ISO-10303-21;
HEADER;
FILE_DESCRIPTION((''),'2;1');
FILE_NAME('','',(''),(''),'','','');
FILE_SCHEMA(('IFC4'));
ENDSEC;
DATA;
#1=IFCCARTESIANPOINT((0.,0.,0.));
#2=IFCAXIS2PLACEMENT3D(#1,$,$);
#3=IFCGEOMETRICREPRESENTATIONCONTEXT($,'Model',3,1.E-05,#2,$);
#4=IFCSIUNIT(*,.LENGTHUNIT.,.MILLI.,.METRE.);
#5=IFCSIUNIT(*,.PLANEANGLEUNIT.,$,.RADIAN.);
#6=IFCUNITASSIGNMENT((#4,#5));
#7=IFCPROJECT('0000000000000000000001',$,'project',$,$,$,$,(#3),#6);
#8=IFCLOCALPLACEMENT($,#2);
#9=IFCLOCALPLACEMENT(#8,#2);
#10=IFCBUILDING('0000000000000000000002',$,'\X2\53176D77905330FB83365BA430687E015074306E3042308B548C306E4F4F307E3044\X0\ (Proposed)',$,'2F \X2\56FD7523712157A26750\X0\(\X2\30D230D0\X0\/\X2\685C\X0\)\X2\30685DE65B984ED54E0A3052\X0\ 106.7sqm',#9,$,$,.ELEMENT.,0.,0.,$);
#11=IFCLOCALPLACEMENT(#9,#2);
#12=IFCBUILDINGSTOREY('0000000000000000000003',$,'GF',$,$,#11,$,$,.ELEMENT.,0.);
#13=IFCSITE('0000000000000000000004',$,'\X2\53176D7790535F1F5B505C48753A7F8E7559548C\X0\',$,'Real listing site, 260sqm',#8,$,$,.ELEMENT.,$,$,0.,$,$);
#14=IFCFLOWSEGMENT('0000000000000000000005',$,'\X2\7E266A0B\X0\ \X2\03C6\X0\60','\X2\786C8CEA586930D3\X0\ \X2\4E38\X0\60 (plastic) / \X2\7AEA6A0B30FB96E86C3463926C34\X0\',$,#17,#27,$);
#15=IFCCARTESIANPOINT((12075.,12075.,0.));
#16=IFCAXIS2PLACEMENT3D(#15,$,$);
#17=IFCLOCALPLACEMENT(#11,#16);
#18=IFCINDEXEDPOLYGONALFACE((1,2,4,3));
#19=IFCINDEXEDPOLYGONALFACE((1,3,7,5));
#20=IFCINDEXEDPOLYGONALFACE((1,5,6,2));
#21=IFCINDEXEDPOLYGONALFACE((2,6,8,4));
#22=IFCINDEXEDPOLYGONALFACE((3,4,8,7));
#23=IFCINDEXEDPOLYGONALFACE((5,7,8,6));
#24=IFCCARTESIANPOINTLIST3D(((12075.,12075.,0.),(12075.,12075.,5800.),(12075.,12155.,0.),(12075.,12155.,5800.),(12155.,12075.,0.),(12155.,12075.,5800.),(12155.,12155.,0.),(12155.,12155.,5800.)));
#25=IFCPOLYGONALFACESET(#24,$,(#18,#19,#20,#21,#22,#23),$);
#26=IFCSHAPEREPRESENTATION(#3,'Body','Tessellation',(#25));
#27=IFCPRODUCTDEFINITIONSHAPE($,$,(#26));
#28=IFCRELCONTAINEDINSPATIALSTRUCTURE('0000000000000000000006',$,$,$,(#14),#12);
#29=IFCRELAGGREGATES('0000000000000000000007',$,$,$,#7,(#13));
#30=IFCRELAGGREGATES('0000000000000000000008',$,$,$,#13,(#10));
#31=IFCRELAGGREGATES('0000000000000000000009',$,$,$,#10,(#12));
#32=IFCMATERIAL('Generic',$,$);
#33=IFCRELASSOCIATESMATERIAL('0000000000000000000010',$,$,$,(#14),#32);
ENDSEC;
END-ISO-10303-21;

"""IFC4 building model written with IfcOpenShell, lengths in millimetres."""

from ifc_helpers import new_model, si_unit, frame, frame_2d, origin, place, context, project, spatial, rectangle, extrude, material, element, save


model = new_model("IFC4")

# Units and contexts
model_context = context("Model", 3, precision=1e-05, world=origin())
ifc_project = project(units=[si_unit("LENGTHUNIT", "METRE", prefix="MILLI"), si_unit("PLANEANGLEUNIT", "RADIAN")], contexts=[model_context])

# Site, building, storey
site_placement = place(None, origin())
site = spatial("IfcSite", under=ifc_project, at=site_placement, Name="北海道弟子屈町美留和", ObjectType="Real listing site, 260sqm", CompositionType="ELEMENT", RefElevation=0.0)
building_placement = place(site_placement, origin())
building = spatial("IfcBuilding", under=site, at=building_placement, Name="北海道・茶室と縁側のある和の住まい (Proposed)", ObjectType="2F 国産無垢材(ヒバ/桜)と左官仕上げ 106.7sqm", CompositionType="ELEMENT", ElevationOfRefHeight=0.0, ElevationOfTerrain=0.0)
storey_placement = place(building_placement, origin())
storey = spatial("IfcBuildingStorey", under=building, at=storey_placement, Name="GF", CompositionType="ELEMENT", Elevation=0.0)

# Flow segment
ifc_material_1 = material(Name="Generic")
flow_segment_placement = place(storey_placement, frame((12075.0, 12075.0, 0.0)))
element("IfcFlowSegment", 1, at=flow_segment_placement, inside=storey, material=ifc_material_1, Name="縦樋 φ60", Description="硬質塩ビ 丸60 (plastic) / 竪樋・雨水排水", context=model_context, shape_type="SweptSolid", body=[
    extrude(rectangle(XDim=80.0, YDim=80.0, at=frame_2d((40.0, 40.0))), frame((12075.0, 12075.0, 0.0)), (0.0, 0.0, 1.0), 5800.0),
])

save(model, "model.ifc")
